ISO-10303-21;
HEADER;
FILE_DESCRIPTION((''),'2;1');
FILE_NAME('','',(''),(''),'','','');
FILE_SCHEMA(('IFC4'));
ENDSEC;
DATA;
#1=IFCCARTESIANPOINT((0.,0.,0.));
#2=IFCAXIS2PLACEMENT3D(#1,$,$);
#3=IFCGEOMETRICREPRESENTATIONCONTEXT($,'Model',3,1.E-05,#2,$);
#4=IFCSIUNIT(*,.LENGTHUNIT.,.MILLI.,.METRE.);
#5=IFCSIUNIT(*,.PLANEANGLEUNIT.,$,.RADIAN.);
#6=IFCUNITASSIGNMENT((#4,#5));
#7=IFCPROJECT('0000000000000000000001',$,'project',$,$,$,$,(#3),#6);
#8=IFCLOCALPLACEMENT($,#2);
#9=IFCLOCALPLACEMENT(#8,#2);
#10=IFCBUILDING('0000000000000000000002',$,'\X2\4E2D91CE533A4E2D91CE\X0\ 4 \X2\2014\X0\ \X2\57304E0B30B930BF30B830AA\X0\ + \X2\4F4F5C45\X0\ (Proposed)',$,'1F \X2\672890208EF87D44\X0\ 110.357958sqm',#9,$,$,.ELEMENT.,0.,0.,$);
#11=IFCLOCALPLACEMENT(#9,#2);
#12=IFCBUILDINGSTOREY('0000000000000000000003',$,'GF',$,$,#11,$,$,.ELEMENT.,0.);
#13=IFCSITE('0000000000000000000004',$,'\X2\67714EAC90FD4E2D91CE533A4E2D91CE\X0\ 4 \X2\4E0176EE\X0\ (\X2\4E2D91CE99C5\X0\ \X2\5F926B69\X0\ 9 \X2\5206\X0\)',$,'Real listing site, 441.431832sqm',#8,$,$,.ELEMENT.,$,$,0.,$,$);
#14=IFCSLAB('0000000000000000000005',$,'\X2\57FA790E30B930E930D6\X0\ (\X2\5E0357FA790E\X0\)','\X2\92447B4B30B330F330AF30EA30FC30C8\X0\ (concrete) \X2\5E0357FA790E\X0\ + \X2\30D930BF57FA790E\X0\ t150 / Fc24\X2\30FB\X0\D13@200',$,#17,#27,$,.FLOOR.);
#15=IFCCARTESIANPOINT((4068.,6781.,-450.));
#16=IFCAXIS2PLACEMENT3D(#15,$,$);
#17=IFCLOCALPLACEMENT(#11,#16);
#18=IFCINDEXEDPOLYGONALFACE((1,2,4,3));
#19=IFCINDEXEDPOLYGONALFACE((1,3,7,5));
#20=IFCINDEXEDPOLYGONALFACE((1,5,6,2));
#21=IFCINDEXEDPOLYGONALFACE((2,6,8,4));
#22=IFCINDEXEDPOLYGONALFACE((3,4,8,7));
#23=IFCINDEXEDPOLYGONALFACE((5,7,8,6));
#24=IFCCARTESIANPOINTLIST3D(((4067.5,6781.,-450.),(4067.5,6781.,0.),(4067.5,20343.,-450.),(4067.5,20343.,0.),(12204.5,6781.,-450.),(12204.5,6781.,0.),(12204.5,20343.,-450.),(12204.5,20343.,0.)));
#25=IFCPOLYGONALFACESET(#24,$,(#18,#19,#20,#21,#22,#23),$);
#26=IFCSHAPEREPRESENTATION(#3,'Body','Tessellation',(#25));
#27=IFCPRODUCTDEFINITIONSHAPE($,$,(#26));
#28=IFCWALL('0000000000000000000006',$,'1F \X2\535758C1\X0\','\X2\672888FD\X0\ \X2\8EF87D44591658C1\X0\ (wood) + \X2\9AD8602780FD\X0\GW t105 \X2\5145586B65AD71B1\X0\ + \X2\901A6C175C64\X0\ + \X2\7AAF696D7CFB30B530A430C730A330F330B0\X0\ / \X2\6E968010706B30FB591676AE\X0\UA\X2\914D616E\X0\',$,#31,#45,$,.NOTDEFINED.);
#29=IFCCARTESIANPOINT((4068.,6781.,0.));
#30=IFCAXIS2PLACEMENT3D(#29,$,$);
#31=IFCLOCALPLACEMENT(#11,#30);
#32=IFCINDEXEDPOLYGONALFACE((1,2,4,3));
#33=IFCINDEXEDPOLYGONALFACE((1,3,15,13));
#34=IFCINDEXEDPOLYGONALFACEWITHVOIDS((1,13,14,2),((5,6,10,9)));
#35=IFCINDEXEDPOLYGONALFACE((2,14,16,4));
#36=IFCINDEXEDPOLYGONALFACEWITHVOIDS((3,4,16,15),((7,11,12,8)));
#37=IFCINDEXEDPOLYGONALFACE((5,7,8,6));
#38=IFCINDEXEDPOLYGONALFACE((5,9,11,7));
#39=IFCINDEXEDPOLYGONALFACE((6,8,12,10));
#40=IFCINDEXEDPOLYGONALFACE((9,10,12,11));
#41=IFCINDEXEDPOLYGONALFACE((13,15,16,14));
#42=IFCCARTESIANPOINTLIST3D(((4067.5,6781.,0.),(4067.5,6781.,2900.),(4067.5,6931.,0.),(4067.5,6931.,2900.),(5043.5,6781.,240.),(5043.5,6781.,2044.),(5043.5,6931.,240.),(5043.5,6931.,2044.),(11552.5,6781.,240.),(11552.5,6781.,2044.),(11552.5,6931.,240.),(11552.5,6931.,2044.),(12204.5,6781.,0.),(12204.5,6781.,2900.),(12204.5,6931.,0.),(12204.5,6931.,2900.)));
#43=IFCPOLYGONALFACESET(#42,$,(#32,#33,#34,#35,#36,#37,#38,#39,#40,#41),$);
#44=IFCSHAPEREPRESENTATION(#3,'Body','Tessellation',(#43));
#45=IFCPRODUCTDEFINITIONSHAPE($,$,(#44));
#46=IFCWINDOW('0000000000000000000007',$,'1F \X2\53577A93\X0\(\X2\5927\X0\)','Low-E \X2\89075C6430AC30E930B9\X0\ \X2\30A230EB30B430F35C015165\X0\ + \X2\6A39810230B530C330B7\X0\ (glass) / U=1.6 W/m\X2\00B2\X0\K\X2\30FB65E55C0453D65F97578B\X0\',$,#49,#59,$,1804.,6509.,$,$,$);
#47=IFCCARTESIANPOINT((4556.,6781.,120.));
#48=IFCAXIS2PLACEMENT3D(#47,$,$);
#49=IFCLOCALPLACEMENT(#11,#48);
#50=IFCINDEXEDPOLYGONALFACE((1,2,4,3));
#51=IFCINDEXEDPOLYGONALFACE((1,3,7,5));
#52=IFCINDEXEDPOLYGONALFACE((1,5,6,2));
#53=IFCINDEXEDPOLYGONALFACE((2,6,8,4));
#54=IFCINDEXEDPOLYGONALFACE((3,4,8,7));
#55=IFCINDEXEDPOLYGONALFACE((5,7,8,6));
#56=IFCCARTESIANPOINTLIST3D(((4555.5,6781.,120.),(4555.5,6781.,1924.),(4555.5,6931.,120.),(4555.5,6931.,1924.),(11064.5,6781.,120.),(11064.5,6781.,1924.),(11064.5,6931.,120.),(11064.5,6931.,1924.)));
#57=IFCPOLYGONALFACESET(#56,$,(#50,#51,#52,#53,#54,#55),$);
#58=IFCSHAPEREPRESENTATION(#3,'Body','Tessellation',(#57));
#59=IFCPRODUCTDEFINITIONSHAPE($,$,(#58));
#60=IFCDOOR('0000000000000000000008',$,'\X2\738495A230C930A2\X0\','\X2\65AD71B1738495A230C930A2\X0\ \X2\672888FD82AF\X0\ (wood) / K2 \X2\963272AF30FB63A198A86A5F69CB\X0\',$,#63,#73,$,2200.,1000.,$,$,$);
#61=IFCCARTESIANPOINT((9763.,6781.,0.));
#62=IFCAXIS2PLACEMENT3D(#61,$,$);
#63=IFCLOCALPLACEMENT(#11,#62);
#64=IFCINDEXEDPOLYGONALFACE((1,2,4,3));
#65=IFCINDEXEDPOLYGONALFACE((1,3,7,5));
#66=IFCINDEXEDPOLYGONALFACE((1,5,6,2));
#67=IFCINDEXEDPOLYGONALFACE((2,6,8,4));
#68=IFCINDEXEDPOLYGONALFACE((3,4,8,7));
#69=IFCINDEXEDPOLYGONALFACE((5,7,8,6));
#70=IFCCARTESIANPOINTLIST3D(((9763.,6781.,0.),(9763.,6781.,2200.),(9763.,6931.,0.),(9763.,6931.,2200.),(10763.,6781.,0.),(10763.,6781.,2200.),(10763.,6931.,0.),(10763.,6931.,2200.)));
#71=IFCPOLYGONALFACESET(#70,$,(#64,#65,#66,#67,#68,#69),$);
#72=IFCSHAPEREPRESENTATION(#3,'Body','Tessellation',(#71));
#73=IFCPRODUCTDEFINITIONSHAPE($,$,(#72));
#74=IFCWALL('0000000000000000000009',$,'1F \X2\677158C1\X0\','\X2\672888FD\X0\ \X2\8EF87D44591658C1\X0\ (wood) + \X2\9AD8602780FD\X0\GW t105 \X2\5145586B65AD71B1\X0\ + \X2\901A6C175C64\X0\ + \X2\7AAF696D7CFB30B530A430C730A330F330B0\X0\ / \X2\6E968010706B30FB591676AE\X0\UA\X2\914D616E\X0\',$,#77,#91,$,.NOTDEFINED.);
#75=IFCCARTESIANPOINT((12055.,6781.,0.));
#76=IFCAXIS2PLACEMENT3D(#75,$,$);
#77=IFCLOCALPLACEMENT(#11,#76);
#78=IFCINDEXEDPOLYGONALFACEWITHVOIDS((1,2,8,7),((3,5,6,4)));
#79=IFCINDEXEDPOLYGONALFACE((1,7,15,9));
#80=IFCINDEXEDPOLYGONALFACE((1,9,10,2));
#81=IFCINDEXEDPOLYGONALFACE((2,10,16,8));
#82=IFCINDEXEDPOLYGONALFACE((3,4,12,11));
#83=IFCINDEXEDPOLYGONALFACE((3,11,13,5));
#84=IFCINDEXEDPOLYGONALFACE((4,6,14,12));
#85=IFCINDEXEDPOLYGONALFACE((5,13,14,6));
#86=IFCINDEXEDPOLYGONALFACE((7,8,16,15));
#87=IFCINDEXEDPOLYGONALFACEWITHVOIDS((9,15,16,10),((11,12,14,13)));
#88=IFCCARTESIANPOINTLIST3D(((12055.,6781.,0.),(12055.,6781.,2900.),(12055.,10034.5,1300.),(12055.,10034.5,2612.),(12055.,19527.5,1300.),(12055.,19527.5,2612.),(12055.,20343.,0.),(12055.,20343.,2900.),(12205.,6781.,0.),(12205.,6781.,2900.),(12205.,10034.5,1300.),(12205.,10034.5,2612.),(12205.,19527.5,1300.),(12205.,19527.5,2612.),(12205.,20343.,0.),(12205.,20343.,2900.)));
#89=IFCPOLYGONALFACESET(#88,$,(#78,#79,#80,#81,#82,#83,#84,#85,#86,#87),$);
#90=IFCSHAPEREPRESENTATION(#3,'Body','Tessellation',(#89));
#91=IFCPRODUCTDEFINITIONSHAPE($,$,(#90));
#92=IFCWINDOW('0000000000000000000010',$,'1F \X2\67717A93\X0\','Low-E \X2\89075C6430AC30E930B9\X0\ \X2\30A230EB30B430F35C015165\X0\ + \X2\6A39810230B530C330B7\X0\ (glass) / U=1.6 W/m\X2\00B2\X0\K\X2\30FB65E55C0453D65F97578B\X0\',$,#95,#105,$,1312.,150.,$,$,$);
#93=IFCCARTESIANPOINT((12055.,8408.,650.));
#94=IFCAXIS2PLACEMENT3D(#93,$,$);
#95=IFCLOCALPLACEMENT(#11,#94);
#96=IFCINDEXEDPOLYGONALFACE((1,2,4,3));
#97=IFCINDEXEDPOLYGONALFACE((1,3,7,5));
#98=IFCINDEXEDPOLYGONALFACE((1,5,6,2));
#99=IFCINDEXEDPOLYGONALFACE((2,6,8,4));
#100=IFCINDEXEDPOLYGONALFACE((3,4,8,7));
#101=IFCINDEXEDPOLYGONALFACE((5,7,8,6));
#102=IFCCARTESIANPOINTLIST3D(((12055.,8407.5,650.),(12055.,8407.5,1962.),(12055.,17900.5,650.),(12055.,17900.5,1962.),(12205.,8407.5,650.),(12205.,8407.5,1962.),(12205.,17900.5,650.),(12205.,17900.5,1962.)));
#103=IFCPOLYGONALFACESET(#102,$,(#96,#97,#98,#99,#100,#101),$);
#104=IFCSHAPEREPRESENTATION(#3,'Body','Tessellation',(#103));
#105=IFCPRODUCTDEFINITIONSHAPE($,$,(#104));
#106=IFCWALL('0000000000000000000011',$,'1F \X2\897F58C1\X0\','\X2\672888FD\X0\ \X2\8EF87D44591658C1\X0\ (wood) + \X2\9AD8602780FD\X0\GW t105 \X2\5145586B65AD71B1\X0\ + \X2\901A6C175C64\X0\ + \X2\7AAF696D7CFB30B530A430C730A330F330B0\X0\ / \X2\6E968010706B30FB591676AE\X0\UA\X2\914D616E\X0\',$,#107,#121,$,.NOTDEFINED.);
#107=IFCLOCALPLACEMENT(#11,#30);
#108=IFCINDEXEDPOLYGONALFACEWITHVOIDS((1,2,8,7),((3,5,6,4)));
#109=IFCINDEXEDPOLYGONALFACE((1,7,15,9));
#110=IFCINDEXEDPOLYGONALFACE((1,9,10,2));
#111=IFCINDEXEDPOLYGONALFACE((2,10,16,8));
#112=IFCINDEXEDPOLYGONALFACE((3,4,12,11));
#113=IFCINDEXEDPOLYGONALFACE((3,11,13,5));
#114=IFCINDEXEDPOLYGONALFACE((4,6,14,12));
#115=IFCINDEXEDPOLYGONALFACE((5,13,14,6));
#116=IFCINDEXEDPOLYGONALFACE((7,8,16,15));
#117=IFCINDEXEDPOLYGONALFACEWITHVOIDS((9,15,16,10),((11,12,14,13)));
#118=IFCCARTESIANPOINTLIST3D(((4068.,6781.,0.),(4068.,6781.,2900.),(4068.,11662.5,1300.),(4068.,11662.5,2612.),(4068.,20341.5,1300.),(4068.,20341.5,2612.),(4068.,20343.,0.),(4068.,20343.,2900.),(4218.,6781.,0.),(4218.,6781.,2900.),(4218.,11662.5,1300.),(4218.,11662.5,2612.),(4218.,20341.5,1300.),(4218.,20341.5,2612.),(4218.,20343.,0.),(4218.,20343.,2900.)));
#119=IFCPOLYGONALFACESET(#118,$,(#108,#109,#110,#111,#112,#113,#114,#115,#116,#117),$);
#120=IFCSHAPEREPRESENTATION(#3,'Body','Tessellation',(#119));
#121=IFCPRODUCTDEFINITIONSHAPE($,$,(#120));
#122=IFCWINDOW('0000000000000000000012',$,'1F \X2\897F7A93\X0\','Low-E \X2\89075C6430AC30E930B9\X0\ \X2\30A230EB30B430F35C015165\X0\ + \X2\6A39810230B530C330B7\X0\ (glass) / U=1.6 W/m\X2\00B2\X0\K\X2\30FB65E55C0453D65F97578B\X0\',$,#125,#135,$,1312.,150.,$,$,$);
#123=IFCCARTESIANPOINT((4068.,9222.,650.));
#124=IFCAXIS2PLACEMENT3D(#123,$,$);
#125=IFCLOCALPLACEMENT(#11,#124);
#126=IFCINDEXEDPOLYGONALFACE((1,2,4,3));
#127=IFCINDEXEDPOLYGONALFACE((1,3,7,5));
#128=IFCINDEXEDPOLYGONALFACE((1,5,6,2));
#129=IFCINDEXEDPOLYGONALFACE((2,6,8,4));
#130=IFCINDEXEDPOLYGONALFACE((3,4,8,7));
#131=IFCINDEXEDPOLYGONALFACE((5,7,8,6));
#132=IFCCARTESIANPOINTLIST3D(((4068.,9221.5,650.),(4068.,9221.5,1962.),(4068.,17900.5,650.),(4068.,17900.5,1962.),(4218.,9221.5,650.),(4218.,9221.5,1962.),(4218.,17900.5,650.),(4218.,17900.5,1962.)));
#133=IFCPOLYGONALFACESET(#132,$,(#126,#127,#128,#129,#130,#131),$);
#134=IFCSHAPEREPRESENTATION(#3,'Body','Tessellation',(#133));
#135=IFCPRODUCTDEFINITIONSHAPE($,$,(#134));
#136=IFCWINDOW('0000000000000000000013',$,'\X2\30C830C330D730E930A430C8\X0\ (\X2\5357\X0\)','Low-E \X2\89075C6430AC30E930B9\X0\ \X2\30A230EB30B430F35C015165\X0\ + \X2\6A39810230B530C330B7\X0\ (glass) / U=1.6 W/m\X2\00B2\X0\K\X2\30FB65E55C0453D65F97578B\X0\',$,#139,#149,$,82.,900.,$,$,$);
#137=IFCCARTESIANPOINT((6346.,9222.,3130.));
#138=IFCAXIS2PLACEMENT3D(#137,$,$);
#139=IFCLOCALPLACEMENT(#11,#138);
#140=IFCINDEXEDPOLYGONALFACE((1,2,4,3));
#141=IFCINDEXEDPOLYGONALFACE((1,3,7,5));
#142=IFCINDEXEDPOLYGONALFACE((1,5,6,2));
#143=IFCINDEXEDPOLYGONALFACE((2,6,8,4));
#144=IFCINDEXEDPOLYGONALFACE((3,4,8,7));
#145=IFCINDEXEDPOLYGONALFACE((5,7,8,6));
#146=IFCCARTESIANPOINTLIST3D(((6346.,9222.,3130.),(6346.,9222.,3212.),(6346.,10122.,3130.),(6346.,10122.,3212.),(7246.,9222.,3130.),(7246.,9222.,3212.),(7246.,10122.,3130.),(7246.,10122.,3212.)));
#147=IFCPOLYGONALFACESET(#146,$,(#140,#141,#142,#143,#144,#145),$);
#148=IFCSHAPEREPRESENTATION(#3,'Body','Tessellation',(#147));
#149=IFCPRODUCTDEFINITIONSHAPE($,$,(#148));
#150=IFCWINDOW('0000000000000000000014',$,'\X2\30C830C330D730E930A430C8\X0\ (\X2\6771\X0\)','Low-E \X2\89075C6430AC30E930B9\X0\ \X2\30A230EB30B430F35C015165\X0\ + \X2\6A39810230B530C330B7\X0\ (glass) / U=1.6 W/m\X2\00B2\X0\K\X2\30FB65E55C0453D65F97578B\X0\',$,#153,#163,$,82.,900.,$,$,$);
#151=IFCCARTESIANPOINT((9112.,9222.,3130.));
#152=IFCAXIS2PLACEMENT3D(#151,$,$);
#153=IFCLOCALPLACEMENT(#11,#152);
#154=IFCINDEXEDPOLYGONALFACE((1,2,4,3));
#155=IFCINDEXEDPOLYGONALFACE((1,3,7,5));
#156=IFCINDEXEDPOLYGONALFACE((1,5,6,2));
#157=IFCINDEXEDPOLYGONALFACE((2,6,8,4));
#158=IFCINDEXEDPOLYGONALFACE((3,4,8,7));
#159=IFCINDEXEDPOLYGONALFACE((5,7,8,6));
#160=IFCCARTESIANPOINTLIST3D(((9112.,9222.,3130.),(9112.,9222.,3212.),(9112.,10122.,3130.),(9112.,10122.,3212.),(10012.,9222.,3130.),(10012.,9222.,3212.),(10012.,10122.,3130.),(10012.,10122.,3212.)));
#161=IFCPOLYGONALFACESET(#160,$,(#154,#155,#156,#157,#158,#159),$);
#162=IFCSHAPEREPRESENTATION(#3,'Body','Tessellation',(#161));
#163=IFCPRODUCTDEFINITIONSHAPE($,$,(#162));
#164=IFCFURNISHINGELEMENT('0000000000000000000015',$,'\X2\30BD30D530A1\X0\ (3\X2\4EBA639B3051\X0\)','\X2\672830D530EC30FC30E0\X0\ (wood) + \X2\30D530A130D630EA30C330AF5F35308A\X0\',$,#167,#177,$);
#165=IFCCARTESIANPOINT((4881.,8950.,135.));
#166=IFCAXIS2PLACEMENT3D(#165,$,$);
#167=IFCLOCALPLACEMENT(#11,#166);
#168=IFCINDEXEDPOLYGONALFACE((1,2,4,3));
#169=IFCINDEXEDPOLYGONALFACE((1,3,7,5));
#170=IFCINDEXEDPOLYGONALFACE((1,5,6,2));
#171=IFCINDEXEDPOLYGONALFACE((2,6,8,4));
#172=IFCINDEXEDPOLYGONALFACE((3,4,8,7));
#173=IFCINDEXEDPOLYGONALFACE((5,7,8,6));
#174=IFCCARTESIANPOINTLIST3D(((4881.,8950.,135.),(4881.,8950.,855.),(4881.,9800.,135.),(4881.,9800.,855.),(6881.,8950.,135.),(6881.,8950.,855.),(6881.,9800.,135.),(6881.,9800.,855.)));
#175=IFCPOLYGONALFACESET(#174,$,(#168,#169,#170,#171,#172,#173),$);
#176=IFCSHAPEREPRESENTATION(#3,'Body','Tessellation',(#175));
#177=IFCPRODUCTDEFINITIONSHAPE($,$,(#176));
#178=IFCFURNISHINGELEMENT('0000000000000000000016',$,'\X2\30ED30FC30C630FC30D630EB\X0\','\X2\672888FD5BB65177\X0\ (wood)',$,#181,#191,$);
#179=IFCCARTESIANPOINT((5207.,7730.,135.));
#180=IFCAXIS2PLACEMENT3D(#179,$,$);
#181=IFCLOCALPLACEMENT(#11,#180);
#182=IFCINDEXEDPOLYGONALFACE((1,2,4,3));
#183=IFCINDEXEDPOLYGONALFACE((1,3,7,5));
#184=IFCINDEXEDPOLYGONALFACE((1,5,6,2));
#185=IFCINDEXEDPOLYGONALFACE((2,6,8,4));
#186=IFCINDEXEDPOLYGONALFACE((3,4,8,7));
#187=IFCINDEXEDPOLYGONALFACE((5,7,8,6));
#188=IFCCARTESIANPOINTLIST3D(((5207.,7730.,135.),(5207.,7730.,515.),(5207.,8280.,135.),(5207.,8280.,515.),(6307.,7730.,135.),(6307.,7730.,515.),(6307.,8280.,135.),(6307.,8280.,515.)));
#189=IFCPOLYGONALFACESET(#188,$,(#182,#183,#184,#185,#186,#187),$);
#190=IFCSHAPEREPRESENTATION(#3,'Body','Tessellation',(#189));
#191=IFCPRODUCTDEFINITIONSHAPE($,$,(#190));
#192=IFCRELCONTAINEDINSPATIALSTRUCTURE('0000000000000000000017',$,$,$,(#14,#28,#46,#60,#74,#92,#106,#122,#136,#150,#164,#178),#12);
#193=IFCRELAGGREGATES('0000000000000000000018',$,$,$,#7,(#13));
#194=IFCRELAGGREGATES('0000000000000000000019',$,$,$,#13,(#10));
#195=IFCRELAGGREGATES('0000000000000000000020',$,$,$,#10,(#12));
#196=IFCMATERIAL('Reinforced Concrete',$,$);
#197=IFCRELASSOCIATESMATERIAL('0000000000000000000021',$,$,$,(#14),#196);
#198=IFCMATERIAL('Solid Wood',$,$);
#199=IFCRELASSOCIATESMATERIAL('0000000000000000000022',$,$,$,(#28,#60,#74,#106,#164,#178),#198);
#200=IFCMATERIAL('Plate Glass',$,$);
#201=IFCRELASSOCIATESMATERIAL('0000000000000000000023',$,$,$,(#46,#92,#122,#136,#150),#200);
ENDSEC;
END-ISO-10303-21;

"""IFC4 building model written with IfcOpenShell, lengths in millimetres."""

from ifc_helpers import new_model, si_unit, frame, frame_2d, origin, place, context, project, spatial, rectangle, extrude, material, element, fill, save


model = new_model("IFC4")

# Units and contexts
model_context = context("Model", 3, precision=1e-05, world=origin())
ifc_project = project(units=[si_unit("LENGTHUNIT", "METRE", prefix="MILLI"), si_unit("PLANEANGLEUNIT", "RADIAN")], contexts=[model_context])

# Site, building, storey
site_placement = place(None, origin())
site = spatial("IfcSite", under=ifc_project, at=site_placement, Name="東京都中野区中野 4 丁目 (中野駅 徒歩 9 分)", ObjectType="Real listing site, 441.431832sqm", CompositionType="ELEMENT", RefElevation=0.0)
building_placement = place(site_placement, origin())
building = spatial("IfcBuilding", under=site, at=building_placement, Name="中野区中野 4 — 地下スタジオ + 住居 (Proposed)", ObjectType="1F 木造軸組 110.357958sqm", CompositionType="ELEMENT", ElevationOfRefHeight=0.0, ElevationOfTerrain=0.0)
storey_placement = place(building_placement, origin())
storey = spatial("IfcBuildingStorey", under=building, at=storey_placement, Name="GF", CompositionType="ELEMENT", Elevation=0.0)

# Slab
ifc_material_1 = material(Name="Reinforced Concrete")
slab_1_placement = place(storey_placement, frame((4068.0, 6781.0, -450.0)))
element("IfcSlab", 1, at=slab_1_placement, inside=storey, material=ifc_material_1, Name="基礎スラブ (布基礎)", Description="鉄筋コンクリート (concrete) 布基礎 + ベタ基礎 t150 / Fc24・D13@200", PredefinedType="FLOOR", context=model_context, shape_type="SweptSolid", body=[
    extrude(rectangle(XDim=8137.0, YDim=13562.0, at=frame_2d((4068.0, 6781.0))), frame((4068.0, 6781.0, -450.0)), (0.0, 0.0, 1.0), 450.0),
])
ifc_material_2 = material(Name="Solid Wood")

# Wall, openings, window, door
wall_1_placement = place(storey_placement, frame((4068.0, 6781.0, 0.0)))
wall_1 = element("IfcWall", 2, at=wall_1_placement, inside=storey, material=ifc_material_2, Name="1F 南壁", Description="木製 軸組外壁 (wood) + 高性能GW t105 充填断熱 + 通気層 + 窯業系サイディング / 準耐火・外皮UA配慮", PredefinedType="NOTDEFINED", context=model_context, shape_type="SweptSolid", body=[
    extrude(rectangle(XDim=8137.0, YDim=150.0, at=frame_2d((4068.0, 75.0))), frame((4068.0, 6781.0, 0.0)), (0.0, 0.0, 1.0), 2900.0),
])
opening_1_placement = place(storey_placement, frame((4556.0, 6781.0, 120.0)))
opening_1 = element("IfcOpeningElement", 3, at=opening_1_placement, cuts=wall_1, PredefinedType="NOTDEFINED", context=model_context, shape_type="SweptSolid", body=[
    extrude(rectangle(XDim=6509.0, YDim=150.0, at=frame_2d((3254.0, 75.0))), frame((4556.0, 6781.0, 120.0)), (0.0, 0.0, 1.0), 1804.0),
])
opening_2_placement = place(storey_placement, frame((9763.0, 6781.0, 0.0)))
opening_2 = element("IfcOpeningElement", 4, at=opening_2_placement, cuts=wall_1, PredefinedType="NOTDEFINED", context=model_context, shape_type="SweptSolid", body=[
    extrude(rectangle(XDim=1000.0, YDim=150.0, at=frame_2d((500.0, 75.0))), frame((9763.0, 6781.0, 0.0)), (0.0, 0.0, 1.0), 2200.0),
])
ifc_material_3 = material(Name="Plate Glass")
window_1_placement = place(storey_placement, frame((4556.0, 6781.0, 120.0)))
window_1 = element("IfcWindow", 5, at=window_1_placement, inside=storey, material=ifc_material_3, Name="1F 南窓(大)", Description="Low-E 複層ガラス アルゴン封入 + 樹脂サッシ (glass) / U=1.6 W/m²K・日射取得型", OverallHeight=1804.0, OverallWidth=6509.0, context=model_context, shape_type="SweptSolid", body=[
    extrude(rectangle(XDim=6509.0, YDim=150.0, at=frame_2d((3254.0, 75.0))), frame((4556.0, 6781.0, 120.0)), (0.0, 0.0, 1.0), 1804.0),
])
fill(opening_1, window_1)
door_placement = place(storey_placement, frame((9763.0, 6781.0, 0.0)))
door = element("IfcDoor", 6, at=door_placement, inside=storey, material=ifc_material_2, Name="玄関ドア", Description="断熱玄関ドア 木製芯 (wood) / K2 防犯・採風機構", OverallHeight=2200.0, OverallWidth=1000.0, context=model_context, shape_type="SweptSolid", body=[
    extrude(rectangle(XDim=1000.0, YDim=150.0, at=frame_2d((500.0, 75.0))), frame((9763.0, 6781.0, 0.0)), (0.0, 0.0, 1.0), 2200.0),
])
fill(opening_2, door)

# Walls, openings, windows
wall_2_placement = place(storey_placement, frame((12055.0, 6781.0, 0.0)))
wall_2 = element("IfcWall", 7, at=wall_2_placement, inside=storey, material=ifc_material_2, Name="1F 東壁", Description="木製 軸組外壁 (wood) + 高性能GW t105 充填断熱 + 通気層 + 窯業系サイディング / 準耐火・外皮UA配慮", PredefinedType="NOTDEFINED", context=model_context, shape_type="SweptSolid", body=[
    extrude(rectangle(XDim=150.0, YDim=13562.0, at=frame_2d((75.0, 6781.0))), frame((12055.0, 6781.0, 0.0)), (0.0, 0.0, 1.0), 2900.0),
])
opening_3_placement = place(storey_placement, frame((12055.0, 8408.0, 650.0)))
opening_3 = element("IfcOpeningElement", 8, at=opening_3_placement, cuts=wall_2, PredefinedType="NOTDEFINED", context=model_context, shape_type="SweptSolid", body=[
    extrude(rectangle(XDim=150.0, YDim=9493.0, at=frame_2d((75.0, 4746.0))), frame((12055.0, 8408.0, 650.0)), (0.0, 0.0, 1.0), 1312.0),
])
window_2_placement = place(storey_placement, frame((12055.0, 8408.0, 650.0)))
window_2 = element("IfcWindow", 9, at=window_2_placement, inside=storey, material=ifc_material_3, Name="1F 東窓", Description="Low-E 複層ガラス アルゴン封入 + 樹脂サッシ (glass) / U=1.6 W/m²K・日射取得型", OverallHeight=1312.0, OverallWidth=150.0, context=model_context, shape_type="SweptSolid", body=[
    extrude(rectangle(XDim=150.0, YDim=9493.0, at=frame_2d((75.0, 4746.0))), frame((12055.0, 8408.0, 650.0)), (0.0, 0.0, 1.0), 1312.0),
])
fill(opening_3, window_2)
wall_3_placement = place(storey_placement, frame((4068.0, 6781.0, 0.0)))
wall_3 = element("IfcWall", 10, at=wall_3_placement, inside=storey, material=ifc_material_2, Name="1F 西壁", Description="木製 軸組外壁 (wood) + 高性能GW t105 充填断熱 + 通気層 + 窯業系サイディング / 準耐火・外皮UA配慮", PredefinedType="NOTDEFINED", context=model_context, shape_type="SweptSolid", body=[
    extrude(rectangle(XDim=150.0, YDim=13562.0, at=frame_2d((75.0, 6781.0))), frame((4068.0, 6781.0, 0.0)), (0.0, 0.0, 1.0), 2900.0),
])
opening_4_placement = place(storey_placement, frame((4068.0, 9222.0, 650.0)))
opening_4 = element("IfcOpeningElement", 11, at=opening_4_placement, cuts=wall_3, PredefinedType="NOTDEFINED", context=model_context, shape_type="SweptSolid", body=[
    extrude(rectangle(XDim=150.0, YDim=8679.0, at=frame_2d((75.0, 4339.0))), frame((4068.0, 9222.0, 650.0)), (0.0, 0.0, 1.0), 1312.0),
])
window_3_placement = place(storey_placement, frame((4068.0, 9222.0, 650.0)))
window_3 = element("IfcWindow", 12, at=window_3_placement, inside=storey, material=ifc_material_3, Name="1F 西窓", Description="Low-E 複層ガラス アルゴン封入 + 樹脂サッシ (glass) / U=1.6 W/m²K・日射取得型", OverallHeight=1312.0, OverallWidth=150.0, context=model_context, shape_type="SweptSolid", body=[
    extrude(rectangle(XDim=150.0, YDim=8679.0, at=frame_2d((75.0, 4339.0))), frame((4068.0, 9222.0, 650.0)), (0.0, 0.0, 1.0), 1312.0),
])
fill(opening_4, window_3)

# Windows
window_4_placement = place(storey_placement, frame((6346.0, 9222.0, 3130.0)))
element("IfcWindow", 13, at=window_4_placement, inside=storey, material=ifc_material_3, Name="トップライト (南)", Description="Low-E 複層ガラス アルゴン封入 + 樹脂サッシ (glass) / U=1.6 W/m²K・日射取得型", OverallHeight=82.0, OverallWidth=900.0, context=model_context, shape_type="SweptSolid", body=[
    extrude(rectangle(XDim=900.0, YDim=900.0, at=frame_2d((450.0, 450.0))), frame((6346.0, 9222.0, 3130.0)), (0.0, 0.0, 1.0), 82.0),
])
window_5_placement = place(storey_placement, frame((9112.0, 9222.0, 3130.0)))
element("IfcWindow", 14, at=window_5_placement, inside=storey, material=ifc_material_3, Name="トップライト (東)", Description="Low-E 複層ガラス アルゴン封入 + 樹脂サッシ (glass) / U=1.6 W/m²K・日射取得型", OverallHeight=82.0, OverallWidth=900.0, context=model_context, shape_type="SweptSolid", body=[
    extrude(rectangle(XDim=900.0, YDim=900.0, at=frame_2d((450.0, 450.0))), frame((9112.0, 9222.0, 3130.0)), (0.0, 0.0, 1.0), 82.0),
])

# Furnishing elements
furnishing_1_placement = place(storey_placement, frame((4881.0, 8950.0, 135.0)))
element("IfcFurnishingElement", 15, at=furnishing_1_placement, inside=storey, material=ifc_material_2, Name="ソファ (3人掛け)", Description="木フレーム (wood) + ファブリック張り", context=model_context, shape_type="SweptSolid", body=[
    extrude(rectangle(XDim=2000.0, YDim=850.0, at=frame_2d((1000.0, 425.0))), frame((4881.0, 8950.0, 135.0)), (0.0, 0.0, 1.0), 720.0),
])
furnishing_2_placement = place(storey_placement, frame((5207.0, 7730.0, 135.0)))
element("IfcFurnishingElement", 16, at=furnishing_2_placement, inside=storey, material=ifc_material_2, Name="ローテーブル", Description="木製家具 (wood)", context=model_context, shape_type="SweptSolid", body=[
    extrude(rectangle(XDim=1100.0, YDim=550.0, at=frame_2d((550.0, 275.0))), frame((5207.0, 7730.0, 135.0)), (0.0, 0.0, 1.0), 380.0),
])

save(model, "model.ifc")
